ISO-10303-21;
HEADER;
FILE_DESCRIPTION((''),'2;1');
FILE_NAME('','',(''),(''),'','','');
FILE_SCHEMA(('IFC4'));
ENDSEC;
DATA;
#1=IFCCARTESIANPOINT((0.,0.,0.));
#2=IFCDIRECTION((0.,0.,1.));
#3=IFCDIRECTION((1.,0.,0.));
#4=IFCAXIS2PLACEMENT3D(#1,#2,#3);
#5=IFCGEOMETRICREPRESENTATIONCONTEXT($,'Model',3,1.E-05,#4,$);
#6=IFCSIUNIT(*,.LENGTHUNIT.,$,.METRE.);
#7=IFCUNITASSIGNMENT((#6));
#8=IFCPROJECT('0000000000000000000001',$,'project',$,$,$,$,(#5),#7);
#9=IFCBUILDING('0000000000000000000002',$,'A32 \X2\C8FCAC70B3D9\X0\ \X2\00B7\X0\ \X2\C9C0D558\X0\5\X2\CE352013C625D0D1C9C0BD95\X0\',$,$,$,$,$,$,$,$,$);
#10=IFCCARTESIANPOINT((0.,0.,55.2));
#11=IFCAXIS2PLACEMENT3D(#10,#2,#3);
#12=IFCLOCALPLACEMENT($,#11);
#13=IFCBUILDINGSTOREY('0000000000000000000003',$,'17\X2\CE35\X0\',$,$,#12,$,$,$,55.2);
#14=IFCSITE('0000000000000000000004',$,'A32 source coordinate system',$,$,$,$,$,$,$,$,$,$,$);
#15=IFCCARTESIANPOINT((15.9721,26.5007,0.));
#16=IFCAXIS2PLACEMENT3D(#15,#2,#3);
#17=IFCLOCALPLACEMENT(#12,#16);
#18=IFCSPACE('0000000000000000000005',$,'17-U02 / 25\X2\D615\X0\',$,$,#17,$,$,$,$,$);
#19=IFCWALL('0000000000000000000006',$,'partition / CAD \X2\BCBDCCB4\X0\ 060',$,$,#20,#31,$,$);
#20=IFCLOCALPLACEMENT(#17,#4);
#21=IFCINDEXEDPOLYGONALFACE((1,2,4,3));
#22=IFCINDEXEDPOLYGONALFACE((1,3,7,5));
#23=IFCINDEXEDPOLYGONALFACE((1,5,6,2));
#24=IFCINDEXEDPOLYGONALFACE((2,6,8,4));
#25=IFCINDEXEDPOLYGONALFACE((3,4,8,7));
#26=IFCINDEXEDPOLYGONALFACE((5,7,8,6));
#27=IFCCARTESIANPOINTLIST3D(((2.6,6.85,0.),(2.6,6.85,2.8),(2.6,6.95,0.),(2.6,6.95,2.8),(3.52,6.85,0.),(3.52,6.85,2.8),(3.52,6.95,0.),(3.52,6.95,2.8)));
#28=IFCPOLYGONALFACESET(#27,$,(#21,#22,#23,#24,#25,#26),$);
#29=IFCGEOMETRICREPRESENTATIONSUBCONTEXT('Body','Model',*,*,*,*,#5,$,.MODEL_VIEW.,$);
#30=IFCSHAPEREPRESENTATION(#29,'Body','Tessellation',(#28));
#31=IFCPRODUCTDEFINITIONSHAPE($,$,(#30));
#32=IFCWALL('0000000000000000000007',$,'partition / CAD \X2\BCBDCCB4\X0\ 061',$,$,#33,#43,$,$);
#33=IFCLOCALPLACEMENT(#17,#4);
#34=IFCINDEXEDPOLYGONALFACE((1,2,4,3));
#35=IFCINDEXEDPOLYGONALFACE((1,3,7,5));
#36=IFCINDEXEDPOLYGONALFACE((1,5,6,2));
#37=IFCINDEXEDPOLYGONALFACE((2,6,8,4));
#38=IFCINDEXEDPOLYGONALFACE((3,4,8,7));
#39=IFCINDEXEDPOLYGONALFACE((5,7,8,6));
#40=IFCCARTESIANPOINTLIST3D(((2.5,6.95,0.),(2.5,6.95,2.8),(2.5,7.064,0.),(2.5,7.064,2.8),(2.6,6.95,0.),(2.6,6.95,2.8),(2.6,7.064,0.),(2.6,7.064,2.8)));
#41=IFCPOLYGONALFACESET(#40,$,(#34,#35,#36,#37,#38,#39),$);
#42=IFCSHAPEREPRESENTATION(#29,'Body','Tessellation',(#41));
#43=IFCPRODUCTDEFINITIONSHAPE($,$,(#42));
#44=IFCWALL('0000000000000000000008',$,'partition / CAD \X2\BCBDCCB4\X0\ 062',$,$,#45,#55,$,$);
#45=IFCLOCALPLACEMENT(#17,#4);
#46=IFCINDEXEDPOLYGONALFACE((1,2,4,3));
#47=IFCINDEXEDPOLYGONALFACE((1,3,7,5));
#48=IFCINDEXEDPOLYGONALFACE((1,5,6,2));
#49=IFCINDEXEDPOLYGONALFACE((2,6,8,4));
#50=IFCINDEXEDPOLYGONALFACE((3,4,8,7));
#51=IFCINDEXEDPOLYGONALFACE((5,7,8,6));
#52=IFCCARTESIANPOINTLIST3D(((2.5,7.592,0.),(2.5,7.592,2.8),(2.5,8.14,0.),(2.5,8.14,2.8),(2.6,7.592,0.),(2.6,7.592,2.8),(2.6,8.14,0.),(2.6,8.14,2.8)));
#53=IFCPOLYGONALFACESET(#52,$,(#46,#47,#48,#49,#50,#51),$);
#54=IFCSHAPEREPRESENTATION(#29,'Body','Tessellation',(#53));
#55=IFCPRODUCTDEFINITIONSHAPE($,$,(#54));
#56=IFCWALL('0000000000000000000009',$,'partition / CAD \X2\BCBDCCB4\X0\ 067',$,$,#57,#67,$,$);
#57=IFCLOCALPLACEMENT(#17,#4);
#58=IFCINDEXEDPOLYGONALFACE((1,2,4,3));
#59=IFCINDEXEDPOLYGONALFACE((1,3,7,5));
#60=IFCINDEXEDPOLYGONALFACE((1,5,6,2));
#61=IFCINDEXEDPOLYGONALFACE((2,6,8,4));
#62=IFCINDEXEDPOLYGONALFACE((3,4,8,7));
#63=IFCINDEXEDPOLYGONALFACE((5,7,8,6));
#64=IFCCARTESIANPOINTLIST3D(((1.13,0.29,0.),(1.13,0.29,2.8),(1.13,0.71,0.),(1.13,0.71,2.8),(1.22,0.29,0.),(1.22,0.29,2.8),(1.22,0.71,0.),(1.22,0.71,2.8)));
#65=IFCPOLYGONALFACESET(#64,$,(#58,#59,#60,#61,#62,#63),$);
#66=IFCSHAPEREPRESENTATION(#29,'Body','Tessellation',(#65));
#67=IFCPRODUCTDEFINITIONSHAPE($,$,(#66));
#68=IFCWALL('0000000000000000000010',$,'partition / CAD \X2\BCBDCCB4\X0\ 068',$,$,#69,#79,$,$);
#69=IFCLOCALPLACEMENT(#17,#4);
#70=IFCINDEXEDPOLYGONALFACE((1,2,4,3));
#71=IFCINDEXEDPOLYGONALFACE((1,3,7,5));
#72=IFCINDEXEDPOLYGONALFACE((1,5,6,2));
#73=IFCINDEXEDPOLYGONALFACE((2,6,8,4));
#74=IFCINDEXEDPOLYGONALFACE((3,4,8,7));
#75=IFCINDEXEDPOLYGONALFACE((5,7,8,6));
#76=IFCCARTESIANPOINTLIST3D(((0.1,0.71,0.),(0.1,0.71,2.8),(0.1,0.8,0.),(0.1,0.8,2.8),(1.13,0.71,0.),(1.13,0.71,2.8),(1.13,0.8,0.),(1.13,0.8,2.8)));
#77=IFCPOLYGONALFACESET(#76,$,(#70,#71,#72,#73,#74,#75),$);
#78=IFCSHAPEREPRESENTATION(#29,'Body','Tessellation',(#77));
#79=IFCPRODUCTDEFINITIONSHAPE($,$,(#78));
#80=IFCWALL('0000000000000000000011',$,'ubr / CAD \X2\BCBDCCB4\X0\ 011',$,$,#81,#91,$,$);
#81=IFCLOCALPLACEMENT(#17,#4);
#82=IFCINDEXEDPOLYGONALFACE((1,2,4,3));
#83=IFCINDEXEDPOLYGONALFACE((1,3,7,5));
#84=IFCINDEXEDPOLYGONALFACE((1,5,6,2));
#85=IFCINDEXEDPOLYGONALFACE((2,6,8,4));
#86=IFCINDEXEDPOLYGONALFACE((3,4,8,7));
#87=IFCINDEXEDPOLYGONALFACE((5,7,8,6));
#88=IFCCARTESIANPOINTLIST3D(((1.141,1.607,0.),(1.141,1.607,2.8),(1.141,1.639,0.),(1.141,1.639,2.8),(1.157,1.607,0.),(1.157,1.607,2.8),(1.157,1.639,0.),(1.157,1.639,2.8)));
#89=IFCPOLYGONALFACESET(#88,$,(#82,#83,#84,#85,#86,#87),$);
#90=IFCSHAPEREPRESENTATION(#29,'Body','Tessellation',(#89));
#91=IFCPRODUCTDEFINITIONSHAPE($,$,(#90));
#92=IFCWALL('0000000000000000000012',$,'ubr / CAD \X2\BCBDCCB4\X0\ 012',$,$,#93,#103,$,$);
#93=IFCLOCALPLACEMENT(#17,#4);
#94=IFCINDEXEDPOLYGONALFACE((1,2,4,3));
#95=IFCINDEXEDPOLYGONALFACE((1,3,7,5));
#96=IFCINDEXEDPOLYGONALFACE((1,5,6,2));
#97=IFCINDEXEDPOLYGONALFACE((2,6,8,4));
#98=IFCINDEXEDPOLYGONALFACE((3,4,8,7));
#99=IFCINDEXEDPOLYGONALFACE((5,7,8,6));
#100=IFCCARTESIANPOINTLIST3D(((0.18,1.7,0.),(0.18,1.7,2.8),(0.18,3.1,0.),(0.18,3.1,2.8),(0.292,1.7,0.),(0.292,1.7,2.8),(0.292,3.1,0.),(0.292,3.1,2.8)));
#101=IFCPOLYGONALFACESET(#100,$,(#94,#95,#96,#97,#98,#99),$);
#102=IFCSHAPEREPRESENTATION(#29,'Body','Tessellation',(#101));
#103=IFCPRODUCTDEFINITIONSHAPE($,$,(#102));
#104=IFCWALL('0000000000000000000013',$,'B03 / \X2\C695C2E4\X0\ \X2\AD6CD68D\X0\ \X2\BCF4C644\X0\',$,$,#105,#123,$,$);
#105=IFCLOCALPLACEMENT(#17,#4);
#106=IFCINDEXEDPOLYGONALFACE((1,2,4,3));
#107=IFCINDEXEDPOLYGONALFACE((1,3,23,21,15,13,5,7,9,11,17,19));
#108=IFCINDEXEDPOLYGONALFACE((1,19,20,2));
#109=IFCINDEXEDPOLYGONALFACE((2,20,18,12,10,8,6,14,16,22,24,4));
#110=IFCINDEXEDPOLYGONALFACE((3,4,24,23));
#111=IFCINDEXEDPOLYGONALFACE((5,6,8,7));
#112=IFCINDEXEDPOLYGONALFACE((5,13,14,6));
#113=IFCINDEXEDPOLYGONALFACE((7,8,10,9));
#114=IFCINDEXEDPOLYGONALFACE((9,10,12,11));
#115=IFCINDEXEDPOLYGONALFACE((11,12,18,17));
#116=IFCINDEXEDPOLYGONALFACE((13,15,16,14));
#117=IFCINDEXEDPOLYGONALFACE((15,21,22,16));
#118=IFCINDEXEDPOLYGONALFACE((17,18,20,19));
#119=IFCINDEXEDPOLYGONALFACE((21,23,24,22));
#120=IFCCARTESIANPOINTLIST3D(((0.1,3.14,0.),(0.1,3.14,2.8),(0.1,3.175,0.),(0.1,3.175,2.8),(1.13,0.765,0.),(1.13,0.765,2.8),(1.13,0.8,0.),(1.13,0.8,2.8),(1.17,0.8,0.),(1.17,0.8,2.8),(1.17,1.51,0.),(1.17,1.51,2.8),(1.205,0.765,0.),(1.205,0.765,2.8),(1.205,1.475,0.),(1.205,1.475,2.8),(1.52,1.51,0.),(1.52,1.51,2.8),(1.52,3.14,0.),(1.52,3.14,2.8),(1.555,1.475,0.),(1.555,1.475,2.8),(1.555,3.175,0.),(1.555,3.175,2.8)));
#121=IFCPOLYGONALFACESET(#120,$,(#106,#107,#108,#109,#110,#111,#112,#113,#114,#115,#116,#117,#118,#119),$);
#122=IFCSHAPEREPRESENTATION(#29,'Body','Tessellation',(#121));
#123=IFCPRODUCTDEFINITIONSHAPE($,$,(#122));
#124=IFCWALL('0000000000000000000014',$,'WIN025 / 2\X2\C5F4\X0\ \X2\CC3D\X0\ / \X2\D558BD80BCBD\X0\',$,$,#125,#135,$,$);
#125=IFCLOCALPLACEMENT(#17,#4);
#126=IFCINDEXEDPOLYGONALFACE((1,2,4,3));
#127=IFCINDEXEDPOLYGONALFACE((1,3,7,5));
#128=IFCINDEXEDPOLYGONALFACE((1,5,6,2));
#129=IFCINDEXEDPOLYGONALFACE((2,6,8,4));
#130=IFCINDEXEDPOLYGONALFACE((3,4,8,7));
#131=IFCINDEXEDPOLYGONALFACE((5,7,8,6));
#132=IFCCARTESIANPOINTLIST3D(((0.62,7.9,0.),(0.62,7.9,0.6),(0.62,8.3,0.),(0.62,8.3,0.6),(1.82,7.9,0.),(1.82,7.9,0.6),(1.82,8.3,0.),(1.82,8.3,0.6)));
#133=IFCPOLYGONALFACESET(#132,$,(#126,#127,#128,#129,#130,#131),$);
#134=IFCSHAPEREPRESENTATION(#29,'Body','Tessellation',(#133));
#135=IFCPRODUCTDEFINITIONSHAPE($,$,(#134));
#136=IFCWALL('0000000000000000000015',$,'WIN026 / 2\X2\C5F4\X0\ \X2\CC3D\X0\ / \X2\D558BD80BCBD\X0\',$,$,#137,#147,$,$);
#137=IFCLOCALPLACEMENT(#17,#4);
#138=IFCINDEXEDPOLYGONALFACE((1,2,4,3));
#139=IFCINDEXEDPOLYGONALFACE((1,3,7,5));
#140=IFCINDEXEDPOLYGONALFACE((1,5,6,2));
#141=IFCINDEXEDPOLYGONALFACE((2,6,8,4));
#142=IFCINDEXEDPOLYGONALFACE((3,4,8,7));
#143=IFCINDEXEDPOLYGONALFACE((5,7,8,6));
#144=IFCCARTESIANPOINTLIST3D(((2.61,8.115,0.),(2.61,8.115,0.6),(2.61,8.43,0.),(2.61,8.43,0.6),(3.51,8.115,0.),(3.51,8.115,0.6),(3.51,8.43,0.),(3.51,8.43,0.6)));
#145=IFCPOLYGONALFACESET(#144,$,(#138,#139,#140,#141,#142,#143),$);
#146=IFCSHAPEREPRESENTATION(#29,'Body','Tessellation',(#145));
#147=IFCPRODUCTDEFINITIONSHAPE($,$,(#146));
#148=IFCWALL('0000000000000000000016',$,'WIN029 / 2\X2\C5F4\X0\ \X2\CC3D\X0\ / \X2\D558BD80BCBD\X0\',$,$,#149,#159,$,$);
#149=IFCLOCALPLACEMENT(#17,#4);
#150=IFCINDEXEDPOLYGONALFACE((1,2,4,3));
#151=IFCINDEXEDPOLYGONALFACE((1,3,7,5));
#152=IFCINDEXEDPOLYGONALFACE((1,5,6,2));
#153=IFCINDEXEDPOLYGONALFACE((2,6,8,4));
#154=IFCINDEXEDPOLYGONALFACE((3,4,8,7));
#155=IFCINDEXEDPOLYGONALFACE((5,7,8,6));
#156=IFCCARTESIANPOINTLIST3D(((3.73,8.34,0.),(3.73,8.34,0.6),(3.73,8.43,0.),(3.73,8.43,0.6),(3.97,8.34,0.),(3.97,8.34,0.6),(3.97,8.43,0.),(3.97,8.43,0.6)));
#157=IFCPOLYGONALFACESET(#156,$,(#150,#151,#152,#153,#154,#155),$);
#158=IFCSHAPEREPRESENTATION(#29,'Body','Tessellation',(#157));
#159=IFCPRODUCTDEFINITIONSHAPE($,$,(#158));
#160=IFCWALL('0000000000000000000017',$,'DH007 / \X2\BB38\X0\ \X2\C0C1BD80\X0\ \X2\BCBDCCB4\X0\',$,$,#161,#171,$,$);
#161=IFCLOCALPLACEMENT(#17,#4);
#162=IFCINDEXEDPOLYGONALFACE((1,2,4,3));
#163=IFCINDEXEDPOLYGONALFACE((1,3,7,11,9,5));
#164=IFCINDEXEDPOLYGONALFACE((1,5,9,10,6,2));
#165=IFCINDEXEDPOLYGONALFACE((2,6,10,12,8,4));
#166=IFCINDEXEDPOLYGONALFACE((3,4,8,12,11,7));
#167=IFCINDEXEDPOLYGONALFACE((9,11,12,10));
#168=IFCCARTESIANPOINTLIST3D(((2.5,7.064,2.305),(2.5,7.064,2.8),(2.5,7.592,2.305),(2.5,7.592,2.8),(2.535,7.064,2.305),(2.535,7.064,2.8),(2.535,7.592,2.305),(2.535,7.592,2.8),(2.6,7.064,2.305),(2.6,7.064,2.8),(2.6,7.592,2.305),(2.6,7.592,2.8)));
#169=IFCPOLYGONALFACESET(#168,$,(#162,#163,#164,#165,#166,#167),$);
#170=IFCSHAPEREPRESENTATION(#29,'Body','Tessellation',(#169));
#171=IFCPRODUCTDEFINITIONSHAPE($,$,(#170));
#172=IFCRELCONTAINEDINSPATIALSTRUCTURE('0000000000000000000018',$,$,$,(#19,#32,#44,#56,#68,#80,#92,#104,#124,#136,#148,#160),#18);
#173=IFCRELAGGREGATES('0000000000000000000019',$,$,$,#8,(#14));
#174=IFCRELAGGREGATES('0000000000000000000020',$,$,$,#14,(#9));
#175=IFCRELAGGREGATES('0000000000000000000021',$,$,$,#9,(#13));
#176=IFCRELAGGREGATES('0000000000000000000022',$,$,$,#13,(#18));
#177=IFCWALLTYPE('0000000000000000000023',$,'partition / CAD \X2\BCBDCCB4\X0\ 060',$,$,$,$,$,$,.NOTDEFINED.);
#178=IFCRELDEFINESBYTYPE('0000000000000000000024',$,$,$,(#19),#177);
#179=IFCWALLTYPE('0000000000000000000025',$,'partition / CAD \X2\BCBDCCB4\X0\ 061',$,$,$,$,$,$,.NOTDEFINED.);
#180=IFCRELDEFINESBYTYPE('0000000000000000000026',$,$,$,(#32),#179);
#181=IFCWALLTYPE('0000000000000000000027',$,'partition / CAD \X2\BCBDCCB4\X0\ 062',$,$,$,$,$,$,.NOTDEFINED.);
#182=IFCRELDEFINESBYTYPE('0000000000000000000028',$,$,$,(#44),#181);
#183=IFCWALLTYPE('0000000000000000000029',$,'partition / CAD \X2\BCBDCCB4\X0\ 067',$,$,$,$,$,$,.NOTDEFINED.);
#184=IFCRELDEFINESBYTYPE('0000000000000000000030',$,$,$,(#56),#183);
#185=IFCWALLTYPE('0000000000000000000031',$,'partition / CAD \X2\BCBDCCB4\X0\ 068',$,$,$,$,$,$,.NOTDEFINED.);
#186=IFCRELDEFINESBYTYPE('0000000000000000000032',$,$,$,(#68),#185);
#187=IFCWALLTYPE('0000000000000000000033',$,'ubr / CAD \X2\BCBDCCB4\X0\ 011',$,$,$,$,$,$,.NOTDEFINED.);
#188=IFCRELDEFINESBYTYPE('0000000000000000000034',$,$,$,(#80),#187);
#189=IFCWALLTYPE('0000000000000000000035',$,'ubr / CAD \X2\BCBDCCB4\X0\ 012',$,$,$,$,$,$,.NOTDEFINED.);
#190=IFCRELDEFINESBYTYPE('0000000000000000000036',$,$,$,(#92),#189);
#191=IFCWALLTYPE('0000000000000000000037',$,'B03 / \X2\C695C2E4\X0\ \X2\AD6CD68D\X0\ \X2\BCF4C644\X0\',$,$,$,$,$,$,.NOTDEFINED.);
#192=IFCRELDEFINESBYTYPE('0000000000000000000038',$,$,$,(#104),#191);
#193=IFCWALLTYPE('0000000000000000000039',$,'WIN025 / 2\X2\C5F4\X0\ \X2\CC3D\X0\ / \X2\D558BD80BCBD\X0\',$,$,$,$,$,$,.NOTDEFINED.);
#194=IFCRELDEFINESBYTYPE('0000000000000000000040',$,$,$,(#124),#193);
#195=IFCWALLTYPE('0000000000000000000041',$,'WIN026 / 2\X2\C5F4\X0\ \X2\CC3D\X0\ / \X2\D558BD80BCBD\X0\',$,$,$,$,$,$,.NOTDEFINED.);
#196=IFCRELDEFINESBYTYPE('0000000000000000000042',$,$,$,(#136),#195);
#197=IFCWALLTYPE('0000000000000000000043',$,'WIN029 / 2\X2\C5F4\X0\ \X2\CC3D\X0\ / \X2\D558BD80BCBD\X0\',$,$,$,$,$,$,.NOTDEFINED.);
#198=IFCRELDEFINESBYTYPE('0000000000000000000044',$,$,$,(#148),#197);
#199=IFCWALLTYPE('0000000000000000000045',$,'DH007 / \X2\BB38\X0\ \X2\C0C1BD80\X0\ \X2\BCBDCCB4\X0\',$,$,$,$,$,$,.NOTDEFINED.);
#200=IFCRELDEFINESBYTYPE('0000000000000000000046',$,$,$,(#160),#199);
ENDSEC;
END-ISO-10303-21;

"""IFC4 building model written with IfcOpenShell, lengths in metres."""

from ifc_helpers import new_model, si_unit, frame, origin, origin_with_axes, place, context, subcontext, project, spatial, polyline, outline, extrude, source, transform, mapped, type_object, type_shapes, element, save


model = new_model("IFC4")

# Units and contexts
model_context = context("Model", 3, precision=1e-05, world=origin_with_axes())
body_context = subcontext(model_context, "Body", "Model", "MODEL_VIEW")
ifc_project = project(units=[si_unit("LENGTHUNIT", "METRE")], contexts=[model_context])

# Site, building, storey, space
site = spatial("IfcSite", under=ifc_project, Name="A32 source coordinate system")
building = spatial("IfcBuilding", under=site, Name="A32 주거동 · 지하5층–옥탑지붕")
storey_placement = place(None, frame((0.0, 0.0, 55.2), z_axis=(0.0, 0.0, 1.0), x_axis=(1.0, 0.0, 0.0)))
storey = spatial("IfcBuildingStorey", under=building, at=storey_placement, Name="17층", Elevation=55.2)
space_1_placement = place(storey_placement, frame((15.9721, 26.5007, 0.0), z_axis=(0.0, 0.0, 1.0), x_axis=(1.0, 0.0, 0.0)))
space_1 = spatial("IfcSpace", under=storey, at=space_1_placement, Name="17-U02 / 25형")

# Walls
wall_type_1 = type_object("IfcWallType", Name="partition / CAD 벽체 060", PredefinedType="NOTDEFINED")
shared_shape_1 = source(origin(), body_context, "Body", "SweptSolid", [
    extrude(outline(polyline([(3.52, 6.85), (2.6, 6.85), (2.6, 6.95), (3.52, 6.95), (3.52, 6.85)])), origin(), (0.0, 0.0, 1.0), 2.8),
])
type_shapes(wall_type_1, [shared_shape_1])
wall_1_placement = place(space_1_placement, origin_with_axes())
element("IfcWall", 1, at=wall_1_placement, inside=space_1, type_object=wall_type_1, Name="partition / CAD 벽체 060", context=body_context, shape_type="MappedRepresentation", body=[
    mapped(shared_shape_1, transform((0.0, 0.0, 0.0), scale=1.0)),
])
wall_type_2 = type_object("IfcWallType", Name="partition / CAD 벽체 061", PredefinedType="NOTDEFINED")
shared_shape_2 = source(origin(), body_context, "Body", "SweptSolid", [
    extrude(outline(polyline([(2.6, 7.064), (2.6, 6.95), (2.5, 6.95), (2.5, 7.064), (2.6, 7.064)])), origin(), (0.0, 0.0, 1.0), 2.8),
])
type_shapes(wall_type_2, [shared_shape_2])
wall_2_placement = place(space_1_placement, origin_with_axes())
element("IfcWall", 2, at=wall_2_placement, inside=space_1, type_object=wall_type_2, Name="partition / CAD 벽체 061", context=body_context, shape_type="MappedRepresentation", body=[
    mapped(shared_shape_2, transform((0.0, 0.0, 0.0), scale=1.0)),
])
wall_type_3 = type_object("IfcWallType", Name="partition / CAD 벽체 062", PredefinedType="NOTDEFINED")
shared_shape_3 = source(origin(), body_context, "Body", "SweptSolid", [
    extrude(outline(polyline([(2.5, 7.592), (2.5, 8.14), (2.6, 8.14), (2.6, 7.592), (2.5, 7.592)])), origin(), (0.0, 0.0, 1.0), 2.8),
])
type_shapes(wall_type_3, [shared_shape_3])
wall_3_placement = place(space_1_placement, origin_with_axes())
element("IfcWall", 3, at=wall_3_placement, inside=space_1, type_object=wall_type_3, Name="partition / CAD 벽체 062", context=body_context, shape_type="MappedRepresentation", body=[
    mapped(shared_shape_3, transform((0.0, 0.0, 0.0), scale=1.0)),
])
wall_type_4 = type_object("IfcWallType", Name="partition / CAD 벽체 067", PredefinedType="NOTDEFINED")
shared_shape_4 = source(origin(), body_context, "Body", "SweptSolid", [
    extrude(outline(polyline([(1.22, 0.71), (1.22, 0.29), (1.13, 0.29), (1.13, 0.71), (1.22, 0.71)])), origin(), (0.0, 0.0, 1.0), 2.8),
])
type_shapes(wall_type_4, [shared_shape_4])
wall_4_placement = place(space_1_placement, origin_with_axes())
element("IfcWall", 4, at=wall_4_placement, inside=space_1, type_object=wall_type_4, Name="partition / CAD 벽체 067", context=body_context, shape_type="MappedRepresentation", body=[
    mapped(shared_shape_4, transform((0.0, 0.0, 0.0), scale=1.0)),
])
wall_type_5 = type_object("IfcWallType", Name="partition / CAD 벽체 068", PredefinedType="NOTDEFINED")
shared_shape_5 = source(origin(), body_context, "Body", "SweptSolid", [
    extrude(outline(polyline([(1.13, 0.8), (1.13, 0.71), (0.1, 0.71), (0.1, 0.8), (1.13, 0.8)])), origin(), (0.0, 0.0, 1.0), 2.8),
])
type_shapes(wall_type_5, [shared_shape_5])
wall_5_placement = place(space_1_placement, origin_with_axes())
element("IfcWall", 5, at=wall_5_placement, inside=space_1, type_object=wall_type_5, Name="partition / CAD 벽체 068", context=body_context, shape_type="MappedRepresentation", body=[
    mapped(shared_shape_5, transform((0.0, 0.0, 0.0), scale=1.0)),
])
wall_type_6 = type_object("IfcWallType", Name="ubr / CAD 벽체 011", PredefinedType="NOTDEFINED")
shared_shape_6 = source(origin(), body_context, "Body", "SweptSolid", [
    extrude(outline(polyline([(1.141, 1.607), (1.141, 1.639), (1.157, 1.639), (1.157, 1.607), (1.141, 1.607)])), origin(), (0.0, 0.0, 1.0), 2.8),
])
type_shapes(wall_type_6, [shared_shape_6])
wall_6_placement = place(space_1_placement, origin_with_axes())
element("IfcWall", 6, at=wall_6_placement, inside=space_1, type_object=wall_type_6, Name="ubr / CAD 벽체 011", context=body_context, shape_type="MappedRepresentation", body=[
    mapped(shared_shape_6, transform((0.0, 0.0, 0.0), scale=1.0)),
])
wall_type_7 = type_object("IfcWallType", Name="ubr / CAD 벽체 012", PredefinedType="NOTDEFINED")
shared_shape_7 = source(origin(), body_context, "Body", "SweptSolid", [
    extrude(outline(polyline([(0.18, 1.7), (0.18, 3.1), (0.292, 3.1), (0.292, 1.7), (0.18, 1.7)])), origin(), (0.0, 0.0, 1.0), 2.8),
])
type_shapes(wall_type_7, [shared_shape_7])
wall_7_placement = place(space_1_placement, origin_with_axes())
element("IfcWall", 7, at=wall_7_placement, inside=space_1, type_object=wall_type_7, Name="ubr / CAD 벽체 012", context=body_context, shape_type="MappedRepresentation", body=[
    mapped(shared_shape_7, transform((0.0, 0.0, 0.0), scale=1.0)),
])
wall_type_8 = type_object("IfcWallType", Name="B03 / 욕실 구획 보완", PredefinedType="NOTDEFINED")
shared_shape_8 = source(origin(), body_context, "Body", "SweptSolid", [
    extrude(outline(polyline([(1.13, 0.765), (1.13, 0.8), (1.17, 0.8), (1.17, 1.51), (1.52, 1.51), (1.52, 3.14), (0.1, 3.14), (0.1, 3.175), (1.555, 3.175), (1.555, 1.475), (1.205, 1.475), (1.205, 0.765), (1.13, 0.765)])), origin(), (0.0, 0.0, 1.0), 2.8),
])
type_shapes(wall_type_8, [shared_shape_8])
wall_8_placement = place(space_1_placement, origin_with_axes())
element("IfcWall", 8, at=wall_8_placement, inside=space_1, type_object=wall_type_8, Name="B03 / 욕실 구획 보완", context=body_context, shape_type="MappedRepresentation", body=[
    mapped(shared_shape_8, transform((0.0, 0.0, 0.0), scale=1.0)),
])
wall_type_9 = type_object("IfcWallType", Name="WIN025 / 2열 창 / 하부벽", PredefinedType="NOTDEFINED")
shared_shape_9 = source(origin(), body_context, "Body", "SweptSolid", [
    extrude(outline(polyline([(1.82, 8.3), (1.82, 7.9), (0.62, 7.9), (0.62, 8.3), (1.82, 8.3)])), origin(), (0.0, 0.0, 1.0), 0.6),
])
type_shapes(wall_type_9, [shared_shape_9])
wall_9_placement = place(space_1_placement, origin_with_axes())
element("IfcWall", 9, at=wall_9_placement, inside=space_1, type_object=wall_type_9, Name="WIN025 / 2열 창 / 하부벽", context=body_context, shape_type="MappedRepresentation", body=[
    mapped(shared_shape_9, transform((0.0, 0.0, 0.0), scale=1.0)),
])
wall_type_10 = type_object("IfcWallType", Name="WIN026 / 2열 창 / 하부벽", PredefinedType="NOTDEFINED")
shared_shape_10 = source(origin(), body_context, "Body", "SweptSolid", [
    extrude(outline(polyline([(3.51, 8.43), (3.51, 8.115), (2.61, 8.115), (2.61, 8.43), (3.51, 8.43)])), origin(), (0.0, 0.0, 1.0), 0.6),
])
type_shapes(wall_type_10, [shared_shape_10])
wall_10_placement = place(space_1_placement, origin_with_axes())
element("IfcWall", 10, at=wall_10_placement, inside=space_1, type_object=wall_type_10, Name="WIN026 / 2열 창 / 하부벽", context=body_context, shape_type="MappedRepresentation", body=[
    mapped(shared_shape_10, transform((0.0, 0.0, 0.0), scale=1.0)),
])
wall_type_11 = type_object("IfcWallType", Name="WIN029 / 2열 창 / 하부벽", PredefinedType="NOTDEFINED")
shared_shape_11 = source(origin(), body_context, "Body", "SweptSolid", [
    extrude(outline(polyline([(3.97, 8.43), (3.97, 8.34), (3.73, 8.34), (3.73, 8.43), (3.97, 8.43)])), origin(), (0.0, 0.0, 1.0), 0.6),
])
type_shapes(wall_type_11, [shared_shape_11])
wall_11_placement = place(space_1_placement, origin_with_axes())
element("IfcWall", 11, at=wall_11_placement, inside=space_1, type_object=wall_type_11, Name="WIN029 / 2열 창 / 하부벽", context=body_context, shape_type="MappedRepresentation", body=[
    mapped(shared_shape_11, transform((0.0, 0.0, 0.0), scale=1.0)),
])
wall_type_12 = type_object("IfcWallType", Name="DH007 / 문 상부 벽체", PredefinedType="NOTDEFINED")
shared_shape_12 = source(origin(), body_context, "Body", "SweptSolid", [
    extrude(outline(polyline([(2.5, 7.592), (2.535, 7.592), (2.6, 7.592), (2.6, 7.064), (2.535, 7.064), (2.5, 7.064), (2.5, 7.592)])), frame((0.0, 0.0, 2.305)), (0.0, 0.0, 1.0), 0.495),
])
type_shapes(wall_type_12, [shared_shape_12])
wall_12_placement = place(space_1_placement, origin_with_axes())
element("IfcWall", 12, at=wall_12_placement, inside=space_1, type_object=wall_type_12, Name="DH007 / 문 상부 벽체", context=body_context, shape_type="MappedRepresentation", body=[
    mapped(shared_shape_12, transform((0.0, 0.0, 0.0), scale=1.0)),
])

save(model, "model.ifc")
